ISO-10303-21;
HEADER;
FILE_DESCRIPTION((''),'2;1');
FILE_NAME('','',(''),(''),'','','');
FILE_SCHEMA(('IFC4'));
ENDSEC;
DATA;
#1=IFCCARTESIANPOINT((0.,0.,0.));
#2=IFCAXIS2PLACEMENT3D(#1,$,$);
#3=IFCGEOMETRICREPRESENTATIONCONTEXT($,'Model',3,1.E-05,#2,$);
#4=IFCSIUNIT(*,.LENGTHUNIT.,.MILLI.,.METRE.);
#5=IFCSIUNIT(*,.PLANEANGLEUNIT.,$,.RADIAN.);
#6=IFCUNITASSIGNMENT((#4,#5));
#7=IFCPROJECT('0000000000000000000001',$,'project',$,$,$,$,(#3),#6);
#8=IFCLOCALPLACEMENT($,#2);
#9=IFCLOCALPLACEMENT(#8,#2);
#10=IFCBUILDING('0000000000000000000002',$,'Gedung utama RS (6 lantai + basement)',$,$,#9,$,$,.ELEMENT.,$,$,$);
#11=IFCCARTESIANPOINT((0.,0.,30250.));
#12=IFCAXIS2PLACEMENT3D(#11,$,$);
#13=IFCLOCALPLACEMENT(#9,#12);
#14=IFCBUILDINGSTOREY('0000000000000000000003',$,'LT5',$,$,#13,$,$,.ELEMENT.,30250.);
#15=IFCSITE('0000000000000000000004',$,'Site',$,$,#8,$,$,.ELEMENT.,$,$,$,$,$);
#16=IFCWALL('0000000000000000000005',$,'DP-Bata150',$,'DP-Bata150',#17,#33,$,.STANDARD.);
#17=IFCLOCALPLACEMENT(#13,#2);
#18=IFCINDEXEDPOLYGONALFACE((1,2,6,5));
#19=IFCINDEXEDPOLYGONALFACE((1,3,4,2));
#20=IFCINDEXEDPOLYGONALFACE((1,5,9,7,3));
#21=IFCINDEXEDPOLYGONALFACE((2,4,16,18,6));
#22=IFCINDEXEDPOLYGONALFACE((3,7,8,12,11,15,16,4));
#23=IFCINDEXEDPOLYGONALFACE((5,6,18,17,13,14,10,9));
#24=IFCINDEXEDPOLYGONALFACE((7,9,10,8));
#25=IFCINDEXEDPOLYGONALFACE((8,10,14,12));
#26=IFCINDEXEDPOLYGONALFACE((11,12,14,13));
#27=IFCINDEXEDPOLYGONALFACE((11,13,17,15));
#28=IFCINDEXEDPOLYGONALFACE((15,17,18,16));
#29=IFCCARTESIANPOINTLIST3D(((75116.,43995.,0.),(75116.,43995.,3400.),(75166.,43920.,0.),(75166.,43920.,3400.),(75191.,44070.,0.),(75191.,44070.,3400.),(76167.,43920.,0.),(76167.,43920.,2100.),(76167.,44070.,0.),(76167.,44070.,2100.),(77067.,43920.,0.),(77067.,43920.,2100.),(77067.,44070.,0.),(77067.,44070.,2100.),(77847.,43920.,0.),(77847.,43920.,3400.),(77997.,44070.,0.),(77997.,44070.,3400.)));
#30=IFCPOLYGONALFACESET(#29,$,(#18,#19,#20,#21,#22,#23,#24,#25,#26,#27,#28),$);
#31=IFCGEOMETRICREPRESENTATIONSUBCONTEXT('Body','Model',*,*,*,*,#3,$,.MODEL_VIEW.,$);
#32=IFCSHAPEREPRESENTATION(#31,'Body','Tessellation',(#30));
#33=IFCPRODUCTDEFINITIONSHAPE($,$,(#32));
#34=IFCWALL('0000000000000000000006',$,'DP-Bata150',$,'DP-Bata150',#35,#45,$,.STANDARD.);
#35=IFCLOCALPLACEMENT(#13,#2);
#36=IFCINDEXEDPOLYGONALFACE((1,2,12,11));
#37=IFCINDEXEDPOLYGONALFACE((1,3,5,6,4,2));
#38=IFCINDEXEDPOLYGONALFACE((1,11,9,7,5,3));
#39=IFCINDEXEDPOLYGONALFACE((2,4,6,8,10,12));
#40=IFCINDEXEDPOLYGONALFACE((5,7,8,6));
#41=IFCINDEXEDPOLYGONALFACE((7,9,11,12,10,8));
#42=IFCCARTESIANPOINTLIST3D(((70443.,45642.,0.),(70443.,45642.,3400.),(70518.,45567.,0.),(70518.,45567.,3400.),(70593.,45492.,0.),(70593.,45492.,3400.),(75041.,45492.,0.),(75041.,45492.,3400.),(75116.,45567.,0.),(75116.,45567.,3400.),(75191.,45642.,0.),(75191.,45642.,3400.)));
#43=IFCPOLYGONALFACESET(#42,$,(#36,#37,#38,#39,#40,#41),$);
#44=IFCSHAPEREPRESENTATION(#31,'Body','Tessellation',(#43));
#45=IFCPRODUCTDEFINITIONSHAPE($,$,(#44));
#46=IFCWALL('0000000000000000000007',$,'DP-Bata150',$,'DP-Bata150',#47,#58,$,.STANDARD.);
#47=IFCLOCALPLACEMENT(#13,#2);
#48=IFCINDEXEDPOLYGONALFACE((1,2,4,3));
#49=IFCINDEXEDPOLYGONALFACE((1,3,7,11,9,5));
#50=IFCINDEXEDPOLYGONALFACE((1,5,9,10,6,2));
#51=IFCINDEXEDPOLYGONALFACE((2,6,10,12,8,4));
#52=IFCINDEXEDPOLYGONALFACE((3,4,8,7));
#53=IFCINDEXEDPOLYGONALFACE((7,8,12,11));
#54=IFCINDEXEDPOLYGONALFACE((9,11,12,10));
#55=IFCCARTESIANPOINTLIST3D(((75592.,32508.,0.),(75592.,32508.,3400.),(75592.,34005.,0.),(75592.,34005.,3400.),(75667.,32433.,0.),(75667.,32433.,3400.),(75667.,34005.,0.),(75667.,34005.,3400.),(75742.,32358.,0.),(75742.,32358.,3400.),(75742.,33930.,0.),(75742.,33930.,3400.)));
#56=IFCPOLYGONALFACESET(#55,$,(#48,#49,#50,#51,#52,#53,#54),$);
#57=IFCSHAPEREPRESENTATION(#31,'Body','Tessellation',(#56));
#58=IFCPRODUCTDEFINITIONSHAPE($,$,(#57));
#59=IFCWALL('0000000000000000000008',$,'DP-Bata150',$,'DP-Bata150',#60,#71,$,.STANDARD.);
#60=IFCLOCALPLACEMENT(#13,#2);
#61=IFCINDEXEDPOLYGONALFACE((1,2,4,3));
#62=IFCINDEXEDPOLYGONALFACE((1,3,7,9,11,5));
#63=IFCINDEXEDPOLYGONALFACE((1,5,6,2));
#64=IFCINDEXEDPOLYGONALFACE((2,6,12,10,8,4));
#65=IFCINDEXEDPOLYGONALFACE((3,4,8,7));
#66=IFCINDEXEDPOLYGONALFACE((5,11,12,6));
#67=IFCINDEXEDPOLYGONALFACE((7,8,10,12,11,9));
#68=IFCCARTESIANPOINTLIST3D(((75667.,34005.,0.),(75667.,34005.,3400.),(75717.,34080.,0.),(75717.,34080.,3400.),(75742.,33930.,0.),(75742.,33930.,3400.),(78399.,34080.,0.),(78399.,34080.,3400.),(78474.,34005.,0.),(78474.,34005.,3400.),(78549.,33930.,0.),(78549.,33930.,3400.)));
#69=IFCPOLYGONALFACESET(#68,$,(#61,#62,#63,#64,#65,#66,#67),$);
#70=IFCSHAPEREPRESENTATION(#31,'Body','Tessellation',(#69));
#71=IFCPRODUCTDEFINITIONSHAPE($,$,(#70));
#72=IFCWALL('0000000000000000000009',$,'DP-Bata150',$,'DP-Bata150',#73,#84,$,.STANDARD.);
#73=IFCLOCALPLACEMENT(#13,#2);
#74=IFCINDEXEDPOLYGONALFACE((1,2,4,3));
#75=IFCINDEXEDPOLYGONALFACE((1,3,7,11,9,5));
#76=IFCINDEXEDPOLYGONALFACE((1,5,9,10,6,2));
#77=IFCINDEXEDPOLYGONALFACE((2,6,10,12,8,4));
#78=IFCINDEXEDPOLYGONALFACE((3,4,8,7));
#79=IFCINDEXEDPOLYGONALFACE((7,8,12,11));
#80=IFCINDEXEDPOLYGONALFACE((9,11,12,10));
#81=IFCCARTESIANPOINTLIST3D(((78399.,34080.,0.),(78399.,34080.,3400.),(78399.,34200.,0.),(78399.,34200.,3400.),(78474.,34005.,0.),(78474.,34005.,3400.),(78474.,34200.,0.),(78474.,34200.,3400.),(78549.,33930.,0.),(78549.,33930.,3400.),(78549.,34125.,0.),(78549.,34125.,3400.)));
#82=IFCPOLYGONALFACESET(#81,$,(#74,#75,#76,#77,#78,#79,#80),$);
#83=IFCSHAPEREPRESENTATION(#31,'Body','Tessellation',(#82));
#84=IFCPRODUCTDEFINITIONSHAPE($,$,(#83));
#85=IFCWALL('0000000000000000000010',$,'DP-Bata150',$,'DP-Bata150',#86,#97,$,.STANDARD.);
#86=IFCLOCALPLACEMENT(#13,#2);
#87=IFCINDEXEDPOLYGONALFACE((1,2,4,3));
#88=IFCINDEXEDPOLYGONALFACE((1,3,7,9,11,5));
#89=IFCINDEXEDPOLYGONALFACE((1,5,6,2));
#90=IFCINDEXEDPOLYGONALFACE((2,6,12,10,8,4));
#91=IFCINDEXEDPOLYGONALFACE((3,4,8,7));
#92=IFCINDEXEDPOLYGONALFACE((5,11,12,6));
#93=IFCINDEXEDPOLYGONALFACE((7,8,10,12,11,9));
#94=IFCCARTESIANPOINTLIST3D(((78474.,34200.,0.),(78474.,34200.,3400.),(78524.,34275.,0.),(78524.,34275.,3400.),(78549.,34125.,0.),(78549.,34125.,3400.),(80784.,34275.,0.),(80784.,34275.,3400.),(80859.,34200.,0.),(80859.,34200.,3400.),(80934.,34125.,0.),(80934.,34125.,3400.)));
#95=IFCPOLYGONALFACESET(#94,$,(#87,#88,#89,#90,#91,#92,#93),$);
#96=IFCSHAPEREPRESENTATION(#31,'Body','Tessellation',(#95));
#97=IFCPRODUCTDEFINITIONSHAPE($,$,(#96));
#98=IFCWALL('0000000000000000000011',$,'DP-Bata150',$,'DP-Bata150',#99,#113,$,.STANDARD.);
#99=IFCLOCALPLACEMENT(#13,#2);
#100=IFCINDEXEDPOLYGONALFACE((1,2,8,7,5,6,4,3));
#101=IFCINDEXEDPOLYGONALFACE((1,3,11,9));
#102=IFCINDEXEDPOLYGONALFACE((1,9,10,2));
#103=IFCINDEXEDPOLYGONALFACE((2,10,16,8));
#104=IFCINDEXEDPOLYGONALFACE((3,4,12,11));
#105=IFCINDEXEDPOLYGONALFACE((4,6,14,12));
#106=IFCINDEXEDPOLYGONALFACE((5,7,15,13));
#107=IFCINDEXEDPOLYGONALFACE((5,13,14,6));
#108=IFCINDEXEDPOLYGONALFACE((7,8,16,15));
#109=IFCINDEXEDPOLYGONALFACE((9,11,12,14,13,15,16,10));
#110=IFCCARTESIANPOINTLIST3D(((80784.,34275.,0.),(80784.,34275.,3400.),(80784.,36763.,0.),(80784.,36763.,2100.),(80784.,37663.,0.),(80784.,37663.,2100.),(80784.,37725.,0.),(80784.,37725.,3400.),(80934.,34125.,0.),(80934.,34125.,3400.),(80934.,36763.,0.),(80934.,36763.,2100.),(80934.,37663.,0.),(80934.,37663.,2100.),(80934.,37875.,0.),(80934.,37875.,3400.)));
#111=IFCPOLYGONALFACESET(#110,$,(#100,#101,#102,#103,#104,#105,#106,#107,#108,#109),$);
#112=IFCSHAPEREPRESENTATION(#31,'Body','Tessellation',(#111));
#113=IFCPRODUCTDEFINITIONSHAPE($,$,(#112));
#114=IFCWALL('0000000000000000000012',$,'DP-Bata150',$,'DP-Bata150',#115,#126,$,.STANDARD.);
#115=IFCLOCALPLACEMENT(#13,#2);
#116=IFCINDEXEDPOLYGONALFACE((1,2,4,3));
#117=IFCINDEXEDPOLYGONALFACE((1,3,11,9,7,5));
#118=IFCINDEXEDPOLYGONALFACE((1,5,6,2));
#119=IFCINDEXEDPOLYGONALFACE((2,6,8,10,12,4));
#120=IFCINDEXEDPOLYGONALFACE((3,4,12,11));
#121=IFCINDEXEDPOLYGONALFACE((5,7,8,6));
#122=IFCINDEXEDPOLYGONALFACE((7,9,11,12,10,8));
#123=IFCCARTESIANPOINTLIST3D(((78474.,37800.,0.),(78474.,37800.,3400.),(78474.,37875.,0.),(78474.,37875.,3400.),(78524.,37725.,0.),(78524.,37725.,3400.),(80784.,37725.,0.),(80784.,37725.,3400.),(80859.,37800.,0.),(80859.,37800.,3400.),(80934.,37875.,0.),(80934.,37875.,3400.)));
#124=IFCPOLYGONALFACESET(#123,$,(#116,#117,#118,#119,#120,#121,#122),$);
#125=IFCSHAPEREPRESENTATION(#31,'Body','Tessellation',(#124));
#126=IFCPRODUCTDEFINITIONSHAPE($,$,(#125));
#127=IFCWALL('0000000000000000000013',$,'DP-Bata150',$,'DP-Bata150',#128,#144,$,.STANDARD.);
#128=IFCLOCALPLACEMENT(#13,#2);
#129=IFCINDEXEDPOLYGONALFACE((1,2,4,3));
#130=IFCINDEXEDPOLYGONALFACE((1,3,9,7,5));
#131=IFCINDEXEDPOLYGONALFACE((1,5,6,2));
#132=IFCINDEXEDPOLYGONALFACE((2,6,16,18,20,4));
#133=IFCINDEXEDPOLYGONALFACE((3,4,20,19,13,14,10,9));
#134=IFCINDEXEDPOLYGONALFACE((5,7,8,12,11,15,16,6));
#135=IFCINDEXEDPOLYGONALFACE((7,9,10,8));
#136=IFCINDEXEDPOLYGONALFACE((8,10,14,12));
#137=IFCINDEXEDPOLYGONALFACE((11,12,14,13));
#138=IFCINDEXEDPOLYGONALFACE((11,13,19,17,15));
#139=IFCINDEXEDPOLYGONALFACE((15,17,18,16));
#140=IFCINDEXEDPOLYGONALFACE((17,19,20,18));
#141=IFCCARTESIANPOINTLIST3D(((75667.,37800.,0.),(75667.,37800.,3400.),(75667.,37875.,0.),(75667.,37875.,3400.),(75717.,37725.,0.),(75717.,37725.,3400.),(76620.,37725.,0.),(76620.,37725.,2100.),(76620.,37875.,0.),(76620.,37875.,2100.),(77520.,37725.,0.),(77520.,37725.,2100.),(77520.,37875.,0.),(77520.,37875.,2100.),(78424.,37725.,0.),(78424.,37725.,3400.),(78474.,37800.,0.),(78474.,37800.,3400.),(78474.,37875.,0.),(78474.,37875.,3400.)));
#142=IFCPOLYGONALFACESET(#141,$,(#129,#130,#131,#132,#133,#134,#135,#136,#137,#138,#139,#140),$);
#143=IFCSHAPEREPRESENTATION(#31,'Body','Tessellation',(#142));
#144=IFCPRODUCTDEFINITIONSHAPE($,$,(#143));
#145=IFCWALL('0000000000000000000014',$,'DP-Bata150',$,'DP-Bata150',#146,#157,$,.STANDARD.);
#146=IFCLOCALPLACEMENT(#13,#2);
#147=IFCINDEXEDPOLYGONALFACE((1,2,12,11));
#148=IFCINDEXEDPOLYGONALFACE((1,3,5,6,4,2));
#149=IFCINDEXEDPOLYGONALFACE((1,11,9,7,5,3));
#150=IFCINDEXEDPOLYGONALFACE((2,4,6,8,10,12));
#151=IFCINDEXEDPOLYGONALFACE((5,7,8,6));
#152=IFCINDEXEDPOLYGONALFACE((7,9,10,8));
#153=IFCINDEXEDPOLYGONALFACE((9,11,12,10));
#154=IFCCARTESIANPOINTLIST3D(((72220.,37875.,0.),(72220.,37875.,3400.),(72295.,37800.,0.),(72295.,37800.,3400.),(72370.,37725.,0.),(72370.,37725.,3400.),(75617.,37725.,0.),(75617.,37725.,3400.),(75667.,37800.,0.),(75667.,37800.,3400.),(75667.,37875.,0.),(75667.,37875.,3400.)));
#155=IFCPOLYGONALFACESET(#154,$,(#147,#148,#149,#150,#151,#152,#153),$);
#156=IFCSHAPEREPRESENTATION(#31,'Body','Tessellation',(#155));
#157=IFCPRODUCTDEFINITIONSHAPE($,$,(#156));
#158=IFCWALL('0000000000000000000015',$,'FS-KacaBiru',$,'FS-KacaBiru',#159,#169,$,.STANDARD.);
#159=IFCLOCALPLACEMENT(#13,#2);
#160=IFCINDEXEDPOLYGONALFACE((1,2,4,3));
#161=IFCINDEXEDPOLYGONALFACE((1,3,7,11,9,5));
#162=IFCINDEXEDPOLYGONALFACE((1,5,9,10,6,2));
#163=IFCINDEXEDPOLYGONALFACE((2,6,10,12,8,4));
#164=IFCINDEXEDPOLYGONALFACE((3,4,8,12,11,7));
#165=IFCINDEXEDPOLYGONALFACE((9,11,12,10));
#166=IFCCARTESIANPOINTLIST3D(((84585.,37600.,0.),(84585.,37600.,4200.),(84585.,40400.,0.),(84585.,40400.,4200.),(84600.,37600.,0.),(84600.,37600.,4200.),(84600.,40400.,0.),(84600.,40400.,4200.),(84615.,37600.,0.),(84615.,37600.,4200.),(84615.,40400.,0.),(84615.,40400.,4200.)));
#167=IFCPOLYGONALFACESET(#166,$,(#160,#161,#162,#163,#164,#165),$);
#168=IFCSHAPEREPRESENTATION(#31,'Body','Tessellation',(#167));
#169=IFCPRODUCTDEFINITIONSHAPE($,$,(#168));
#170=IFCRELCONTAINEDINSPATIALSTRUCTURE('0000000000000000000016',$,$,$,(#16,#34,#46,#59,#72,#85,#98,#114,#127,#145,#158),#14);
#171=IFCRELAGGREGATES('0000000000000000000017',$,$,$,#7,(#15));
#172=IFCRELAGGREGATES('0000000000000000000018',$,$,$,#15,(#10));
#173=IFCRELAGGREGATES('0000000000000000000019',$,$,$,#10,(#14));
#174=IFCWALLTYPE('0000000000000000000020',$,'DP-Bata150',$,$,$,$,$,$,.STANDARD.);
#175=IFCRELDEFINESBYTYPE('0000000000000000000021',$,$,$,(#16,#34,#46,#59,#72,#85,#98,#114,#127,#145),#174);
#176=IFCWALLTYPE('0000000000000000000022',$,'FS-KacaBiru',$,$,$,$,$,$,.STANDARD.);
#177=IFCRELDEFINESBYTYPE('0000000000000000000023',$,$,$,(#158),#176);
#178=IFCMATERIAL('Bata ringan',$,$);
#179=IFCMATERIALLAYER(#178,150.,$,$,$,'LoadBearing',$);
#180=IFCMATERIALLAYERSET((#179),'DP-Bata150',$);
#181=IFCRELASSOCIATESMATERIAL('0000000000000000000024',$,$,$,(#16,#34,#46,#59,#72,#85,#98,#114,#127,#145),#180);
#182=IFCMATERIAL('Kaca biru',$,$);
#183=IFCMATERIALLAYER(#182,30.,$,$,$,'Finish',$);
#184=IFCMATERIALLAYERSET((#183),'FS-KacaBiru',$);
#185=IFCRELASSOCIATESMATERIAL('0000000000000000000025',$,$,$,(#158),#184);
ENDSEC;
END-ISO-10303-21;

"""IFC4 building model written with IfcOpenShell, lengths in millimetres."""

from ifc_helpers import new_model, si_unit, frame, frame_2d, origin, place, context, subcontext, project, spatial, polyline, rectangle, outline, extrude, material, layer, layer_set, layer_usage, type_object, element, save


model = new_model("IFC4")

# Units and contexts
model_context = context("Model", 3, precision=1e-05, world=origin())
body_context = subcontext(model_context, "Body", "Model", "MODEL_VIEW")
ifc_project = project(units=[si_unit("LENGTHUNIT", "METRE", prefix="MILLI"), si_unit("PLANEANGLEUNIT", "RADIAN")], contexts=[model_context])

# Site, building, storey
site_placement = place(None, origin())
site = spatial("IfcSite", under=ifc_project, at=site_placement, Name="Site", CompositionType="ELEMENT")
building_placement = place(site_placement, origin())
building = spatial("IfcBuilding", under=site, at=building_placement, Name="Gedung utama RS (6 lantai + basement)", CompositionType="ELEMENT")
storey_placement = place(building_placement, frame((0.0, 0.0, 30250.0)))
storey = spatial("IfcBuildingStorey", under=building, at=storey_placement, Name="LT5", CompositionType="ELEMENT", Elevation=30250.0)

# Shared definitions
ifc_material_1 = material(Name="Bata ringan")
ifc_layer_1 = layer(ifc_material_1, 150.0, Category="LoadBearing")
ifc_layer_set_1 = layer_set([ifc_layer_1], Name="DP-Bata150")
ifc_layer_usage_1 = layer_usage(ifc_layer_set_1, "AXIS2", "NEGATIVE", 75.0)
wall_type_1 = type_object("IfcWallType", Name="DP-Bata150", PredefinedType="STANDARD")

# Wall, opening
wall_1_placement = place(storey_placement, frame((77922.0, 43995.0, 0.0), z_axis=(0.0, 0.0, 1.0), x_axis=(-1.0, 0.0, 0.0)))
wall_1 = element("IfcWall", 1, at=wall_1_placement, inside=storey, type_object=wall_type_1, material=ifc_layer_usage_1, Name="DP-Bata150", ObjectType="DP-Bata150", PredefinedType="STANDARD", context=body_context, shape_type="SweptSolid", body=[
    extrude(outline(polyline([(-75.0, -75.0), (0.0, 0.0), (75.0, 75.0), (2756.0, 75.0), (2806.0, 0.0), (2731.0, -75.0), (-75.0, -75.0)])), origin(), (0.0, 0.0, 1.0), 3400.0),
])
opening_1_placement = place(wall_1_placement, frame((855.0, 0.0, 0.0), z_axis=(0.0, 0.0, 1.0), x_axis=(1.0, 0.0, 0.0)))
element("IfcOpeningElement", 2, at=opening_1_placement, cuts=wall_1, PredefinedType="OPENING", context=body_context, shape_type="SweptSolid", body=[
    extrude(rectangle(XDim=900.0, YDim=170.0, at=frame_2d((450.0, 0.0))), origin(), (0.0, 0.0, 1.0), 2100.0),
])

# Walls
wall_2_placement = place(storey_placement, frame((75116.0, 45567.0, 0.0), z_axis=(0.0, 0.0, 1.0), x_axis=(-1.0, 0.0, 0.0)))
element("IfcWall", 3, at=wall_2_placement, inside=storey, type_object=wall_type_1, material=ifc_layer_usage_1, Name="DP-Bata150", ObjectType="DP-Bata150", PredefinedType="STANDARD", context=body_context, shape_type="SweptSolid", body=[
    extrude(outline(polyline([(-75.0, -75.0), (0.0, 0.0), (75.0, 75.0), (4523.0, 75.0), (4598.0, 0.0), (4673.0, -75.0), (-75.0, -75.0)])), origin(), (0.0, 0.0, 1.0), 3400.0),
])
wall_3_placement = place(storey_placement, frame((75667.0, 32433.0, 0.0), z_axis=(0.0, 0.0, 1.0), x_axis=(0.0, 1.0, 0.0)))
element("IfcWall", 4, at=wall_3_placement, inside=storey, type_object=wall_type_1, material=ifc_layer_usage_1, Name="DP-Bata150", ObjectType="DP-Bata150", PredefinedType="STANDARD", context=body_context, shape_type="SweptSolid", body=[
    extrude(outline(polyline([(-75.0, -75.0), (0.0, 0.0), (75.0, 75.0), (1572.0, 75.0), (1572.0, 0.0), (1497.0, -75.0), (-75.0, -75.0)])), origin(), (0.0, 0.0, 1.0), 3400.0),
])
wall_4_placement = place(storey_placement, frame((75667.0, 34005.0, 0.0), z_axis=(0.0, 0.0, 1.0), x_axis=(1.0, 0.0, 0.0)))
element("IfcWall", 5, at=wall_4_placement, inside=storey, type_object=wall_type_1, material=ifc_layer_usage_1, Name="DP-Bata150", ObjectType="DP-Bata150", PredefinedType="STANDARD", context=body_context, shape_type="SweptSolid", body=[
    extrude(outline(polyline([(75.0, -75.0), (0.0, 0.0), (50.0, 75.0), (2732.0, 75.0), (2807.0, 0.0), (2882.0, -75.0), (75.0, -75.0)])), origin(), (0.0, 0.0, 1.0), 3400.0),
])
wall_5_placement = place(storey_placement, frame((78474.0, 34005.0, 0.0), z_axis=(0.0, 0.0, 1.0), x_axis=(0.0, 1.0, 0.0)))
element("IfcWall", 6, at=wall_5_placement, inside=storey, type_object=wall_type_1, material=ifc_layer_usage_1, Name="DP-Bata150", ObjectType="DP-Bata150", PredefinedType="STANDARD", context=body_context, shape_type="SweptSolid", body=[
    extrude(outline(polyline([(-75.0, -75.0), (0.0, 0.0), (75.0, 75.0), (195.0, 75.0), (195.0, 0.0), (120.0, -75.0), (-75.0, -75.0)])), origin(), (0.0, 0.0, 1.0), 3400.0),
])
wall_6_placement = place(storey_placement, frame((78474.0, 34200.0, 0.0), z_axis=(0.0, 0.0, 1.0), x_axis=(1.0, 0.0, 0.0)))
element("IfcWall", 7, at=wall_6_placement, inside=storey, type_object=wall_type_1, material=ifc_layer_usage_1, Name="DP-Bata150", ObjectType="DP-Bata150", PredefinedType="STANDARD", context=body_context, shape_type="SweptSolid", body=[
    extrude(outline(polyline([(75.0, -75.0), (0.0, 0.0), (50.0, 75.0), (2310.0, 75.0), (2385.0, 0.0), (2460.0, -75.0), (75.0, -75.0)])), origin(), (0.0, 0.0, 1.0), 3400.0),
])

# Wall, opening
wall_7_placement = place(storey_placement, frame((80859.0, 34200.0, 0.0), z_axis=(0.0, 0.0, 1.0), x_axis=(0.0, 1.0, 0.0)))
wall_7 = element("IfcWall", 8, at=wall_7_placement, inside=storey, type_object=wall_type_1, material=ifc_layer_usage_1, Name="DP-Bata150", ObjectType="DP-Bata150", PredefinedType="STANDARD", context=body_context, shape_type="SweptSolid", body=[
    extrude(outline(polyline([(-75.0, -75.0), (0.0, 0.0), (75.0, 75.0), (3525.0, 75.0), (3600.0, 0.0), (3675.0, -75.0), (-75.0, -75.0)])), origin(), (0.0, 0.0, 1.0), 3400.0),
])
opening_2_placement = place(wall_7_placement, frame((2563.0, 0.0, 0.0), z_axis=(0.0, 0.0, 1.0), x_axis=(1.0, 0.0, 0.0)))
element("IfcOpeningElement", 9, at=opening_2_placement, cuts=wall_7, PredefinedType="OPENING", context=body_context, shape_type="SweptSolid", body=[
    extrude(rectangle(XDim=900.0, YDim=170.0, at=frame_2d((450.0, 0.0))), origin(), (0.0, 0.0, 1.0), 2100.0),
])

# Wall
wall_8_placement = place(storey_placement, frame((80859.0, 37800.0, 0.0), z_axis=(0.0, 0.0, 1.0), x_axis=(-1.0, 0.0, 0.0)))
element("IfcWall", 10, at=wall_8_placement, inside=storey, type_object=wall_type_1, material=ifc_layer_usage_1, Name="DP-Bata150", ObjectType="DP-Bata150", PredefinedType="STANDARD", context=body_context, shape_type="SweptSolid", body=[
    extrude(outline(polyline([(-75.0, -75.0), (0.0, 0.0), (75.0, 75.0), (2335.0, 75.0), (2385.0, 0.0), (2385.0, -75.0), (-75.0, -75.0)])), origin(), (0.0, 0.0, 1.0), 3400.0),
])

# Wall, opening
wall_9_placement = place(storey_placement, frame((78474.0, 37800.0, 0.0), z_axis=(0.0, 0.0, 1.0), x_axis=(-1.0, 0.0, 0.0)))
wall_9 = element("IfcWall", 11, at=wall_9_placement, inside=storey, type_object=wall_type_1, material=ifc_layer_usage_1, Name="DP-Bata150", ObjectType="DP-Bata150", PredefinedType="STANDARD", context=body_context, shape_type="SweptSolid", body=[
    extrude(outline(polyline([(0.0, -75.0), (0.0, 0.0), (50.0, 75.0), (2757.0, 75.0), (2807.0, 0.0), (2807.0, -75.0), (0.0, -75.0)])), origin(), (0.0, 0.0, 1.0), 3400.0),
])
opening_3_placement = place(wall_9_placement, frame((954.0, 0.0, 0.0), z_axis=(0.0, 0.0, 1.0), x_axis=(1.0, 0.0, 0.0)))
element("IfcOpeningElement", 12, at=opening_3_placement, cuts=wall_9, PredefinedType="OPENING", context=body_context, shape_type="SweptSolid", body=[
    extrude(rectangle(XDim=900.0, YDim=170.0, at=frame_2d((450.0, 0.0))), origin(), (0.0, 0.0, 1.0), 2100.0),
])

# Walls
wall_10_placement = place(storey_placement, frame((75667.0, 37800.0, 0.0), z_axis=(0.0, 0.0, 1.0), x_axis=(-1.0, 0.0, 0.0)))
element("IfcWall", 13, at=wall_10_placement, inside=storey, type_object=wall_type_1, material=ifc_layer_usage_1, Name="DP-Bata150", ObjectType="DP-Bata150", PredefinedType="STANDARD", context=body_context, shape_type="SweptSolid", body=[
    extrude(outline(polyline([(0.0, -75.0), (0.0, 0.0), (50.0, 75.0), (3297.0, 75.0), (3372.0, 0.0), (3447.0, -75.0), (0.0, -75.0)])), origin(), (0.0, 0.0, 1.0), 3400.0),
])
ifc_material_2 = material(Name="Kaca biru")
ifc_layer_2 = layer(ifc_material_2, 30.0, Category="Finish")
ifc_layer_set_2 = layer_set([ifc_layer_2], Name="FS-KacaBiru")
ifc_layer_usage_2 = layer_usage(ifc_layer_set_2, "AXIS2", "NEGATIVE", 15.0)
wall_type_2 = type_object("IfcWallType", Name="FS-KacaBiru", PredefinedType="STANDARD")
wall_11_placement = place(storey_placement, frame((84600.0, 40400.0, 0.0), z_axis=(0.0, 0.0, 1.0), x_axis=(0.0, -1.0, 0.0)))
element("IfcWall", 14, at=wall_11_placement, inside=storey, type_object=wall_type_2, material=ifc_layer_usage_2, Name="FS-KacaBiru", ObjectType="FS-KacaBiru", PredefinedType="STANDARD", context=body_context, shape_type="SweptSolid", body=[
    extrude(outline(polyline([(0.0, -15.0), (0.0, 0.0), (0.0, 15.0), (2800.0, 15.0), (2800.0, 0.0), (2800.0, -15.0), (0.0, -15.0)])), origin(), (0.0, 0.0, 1.0), 4200.0),
])

save(model, "model.ifc")
